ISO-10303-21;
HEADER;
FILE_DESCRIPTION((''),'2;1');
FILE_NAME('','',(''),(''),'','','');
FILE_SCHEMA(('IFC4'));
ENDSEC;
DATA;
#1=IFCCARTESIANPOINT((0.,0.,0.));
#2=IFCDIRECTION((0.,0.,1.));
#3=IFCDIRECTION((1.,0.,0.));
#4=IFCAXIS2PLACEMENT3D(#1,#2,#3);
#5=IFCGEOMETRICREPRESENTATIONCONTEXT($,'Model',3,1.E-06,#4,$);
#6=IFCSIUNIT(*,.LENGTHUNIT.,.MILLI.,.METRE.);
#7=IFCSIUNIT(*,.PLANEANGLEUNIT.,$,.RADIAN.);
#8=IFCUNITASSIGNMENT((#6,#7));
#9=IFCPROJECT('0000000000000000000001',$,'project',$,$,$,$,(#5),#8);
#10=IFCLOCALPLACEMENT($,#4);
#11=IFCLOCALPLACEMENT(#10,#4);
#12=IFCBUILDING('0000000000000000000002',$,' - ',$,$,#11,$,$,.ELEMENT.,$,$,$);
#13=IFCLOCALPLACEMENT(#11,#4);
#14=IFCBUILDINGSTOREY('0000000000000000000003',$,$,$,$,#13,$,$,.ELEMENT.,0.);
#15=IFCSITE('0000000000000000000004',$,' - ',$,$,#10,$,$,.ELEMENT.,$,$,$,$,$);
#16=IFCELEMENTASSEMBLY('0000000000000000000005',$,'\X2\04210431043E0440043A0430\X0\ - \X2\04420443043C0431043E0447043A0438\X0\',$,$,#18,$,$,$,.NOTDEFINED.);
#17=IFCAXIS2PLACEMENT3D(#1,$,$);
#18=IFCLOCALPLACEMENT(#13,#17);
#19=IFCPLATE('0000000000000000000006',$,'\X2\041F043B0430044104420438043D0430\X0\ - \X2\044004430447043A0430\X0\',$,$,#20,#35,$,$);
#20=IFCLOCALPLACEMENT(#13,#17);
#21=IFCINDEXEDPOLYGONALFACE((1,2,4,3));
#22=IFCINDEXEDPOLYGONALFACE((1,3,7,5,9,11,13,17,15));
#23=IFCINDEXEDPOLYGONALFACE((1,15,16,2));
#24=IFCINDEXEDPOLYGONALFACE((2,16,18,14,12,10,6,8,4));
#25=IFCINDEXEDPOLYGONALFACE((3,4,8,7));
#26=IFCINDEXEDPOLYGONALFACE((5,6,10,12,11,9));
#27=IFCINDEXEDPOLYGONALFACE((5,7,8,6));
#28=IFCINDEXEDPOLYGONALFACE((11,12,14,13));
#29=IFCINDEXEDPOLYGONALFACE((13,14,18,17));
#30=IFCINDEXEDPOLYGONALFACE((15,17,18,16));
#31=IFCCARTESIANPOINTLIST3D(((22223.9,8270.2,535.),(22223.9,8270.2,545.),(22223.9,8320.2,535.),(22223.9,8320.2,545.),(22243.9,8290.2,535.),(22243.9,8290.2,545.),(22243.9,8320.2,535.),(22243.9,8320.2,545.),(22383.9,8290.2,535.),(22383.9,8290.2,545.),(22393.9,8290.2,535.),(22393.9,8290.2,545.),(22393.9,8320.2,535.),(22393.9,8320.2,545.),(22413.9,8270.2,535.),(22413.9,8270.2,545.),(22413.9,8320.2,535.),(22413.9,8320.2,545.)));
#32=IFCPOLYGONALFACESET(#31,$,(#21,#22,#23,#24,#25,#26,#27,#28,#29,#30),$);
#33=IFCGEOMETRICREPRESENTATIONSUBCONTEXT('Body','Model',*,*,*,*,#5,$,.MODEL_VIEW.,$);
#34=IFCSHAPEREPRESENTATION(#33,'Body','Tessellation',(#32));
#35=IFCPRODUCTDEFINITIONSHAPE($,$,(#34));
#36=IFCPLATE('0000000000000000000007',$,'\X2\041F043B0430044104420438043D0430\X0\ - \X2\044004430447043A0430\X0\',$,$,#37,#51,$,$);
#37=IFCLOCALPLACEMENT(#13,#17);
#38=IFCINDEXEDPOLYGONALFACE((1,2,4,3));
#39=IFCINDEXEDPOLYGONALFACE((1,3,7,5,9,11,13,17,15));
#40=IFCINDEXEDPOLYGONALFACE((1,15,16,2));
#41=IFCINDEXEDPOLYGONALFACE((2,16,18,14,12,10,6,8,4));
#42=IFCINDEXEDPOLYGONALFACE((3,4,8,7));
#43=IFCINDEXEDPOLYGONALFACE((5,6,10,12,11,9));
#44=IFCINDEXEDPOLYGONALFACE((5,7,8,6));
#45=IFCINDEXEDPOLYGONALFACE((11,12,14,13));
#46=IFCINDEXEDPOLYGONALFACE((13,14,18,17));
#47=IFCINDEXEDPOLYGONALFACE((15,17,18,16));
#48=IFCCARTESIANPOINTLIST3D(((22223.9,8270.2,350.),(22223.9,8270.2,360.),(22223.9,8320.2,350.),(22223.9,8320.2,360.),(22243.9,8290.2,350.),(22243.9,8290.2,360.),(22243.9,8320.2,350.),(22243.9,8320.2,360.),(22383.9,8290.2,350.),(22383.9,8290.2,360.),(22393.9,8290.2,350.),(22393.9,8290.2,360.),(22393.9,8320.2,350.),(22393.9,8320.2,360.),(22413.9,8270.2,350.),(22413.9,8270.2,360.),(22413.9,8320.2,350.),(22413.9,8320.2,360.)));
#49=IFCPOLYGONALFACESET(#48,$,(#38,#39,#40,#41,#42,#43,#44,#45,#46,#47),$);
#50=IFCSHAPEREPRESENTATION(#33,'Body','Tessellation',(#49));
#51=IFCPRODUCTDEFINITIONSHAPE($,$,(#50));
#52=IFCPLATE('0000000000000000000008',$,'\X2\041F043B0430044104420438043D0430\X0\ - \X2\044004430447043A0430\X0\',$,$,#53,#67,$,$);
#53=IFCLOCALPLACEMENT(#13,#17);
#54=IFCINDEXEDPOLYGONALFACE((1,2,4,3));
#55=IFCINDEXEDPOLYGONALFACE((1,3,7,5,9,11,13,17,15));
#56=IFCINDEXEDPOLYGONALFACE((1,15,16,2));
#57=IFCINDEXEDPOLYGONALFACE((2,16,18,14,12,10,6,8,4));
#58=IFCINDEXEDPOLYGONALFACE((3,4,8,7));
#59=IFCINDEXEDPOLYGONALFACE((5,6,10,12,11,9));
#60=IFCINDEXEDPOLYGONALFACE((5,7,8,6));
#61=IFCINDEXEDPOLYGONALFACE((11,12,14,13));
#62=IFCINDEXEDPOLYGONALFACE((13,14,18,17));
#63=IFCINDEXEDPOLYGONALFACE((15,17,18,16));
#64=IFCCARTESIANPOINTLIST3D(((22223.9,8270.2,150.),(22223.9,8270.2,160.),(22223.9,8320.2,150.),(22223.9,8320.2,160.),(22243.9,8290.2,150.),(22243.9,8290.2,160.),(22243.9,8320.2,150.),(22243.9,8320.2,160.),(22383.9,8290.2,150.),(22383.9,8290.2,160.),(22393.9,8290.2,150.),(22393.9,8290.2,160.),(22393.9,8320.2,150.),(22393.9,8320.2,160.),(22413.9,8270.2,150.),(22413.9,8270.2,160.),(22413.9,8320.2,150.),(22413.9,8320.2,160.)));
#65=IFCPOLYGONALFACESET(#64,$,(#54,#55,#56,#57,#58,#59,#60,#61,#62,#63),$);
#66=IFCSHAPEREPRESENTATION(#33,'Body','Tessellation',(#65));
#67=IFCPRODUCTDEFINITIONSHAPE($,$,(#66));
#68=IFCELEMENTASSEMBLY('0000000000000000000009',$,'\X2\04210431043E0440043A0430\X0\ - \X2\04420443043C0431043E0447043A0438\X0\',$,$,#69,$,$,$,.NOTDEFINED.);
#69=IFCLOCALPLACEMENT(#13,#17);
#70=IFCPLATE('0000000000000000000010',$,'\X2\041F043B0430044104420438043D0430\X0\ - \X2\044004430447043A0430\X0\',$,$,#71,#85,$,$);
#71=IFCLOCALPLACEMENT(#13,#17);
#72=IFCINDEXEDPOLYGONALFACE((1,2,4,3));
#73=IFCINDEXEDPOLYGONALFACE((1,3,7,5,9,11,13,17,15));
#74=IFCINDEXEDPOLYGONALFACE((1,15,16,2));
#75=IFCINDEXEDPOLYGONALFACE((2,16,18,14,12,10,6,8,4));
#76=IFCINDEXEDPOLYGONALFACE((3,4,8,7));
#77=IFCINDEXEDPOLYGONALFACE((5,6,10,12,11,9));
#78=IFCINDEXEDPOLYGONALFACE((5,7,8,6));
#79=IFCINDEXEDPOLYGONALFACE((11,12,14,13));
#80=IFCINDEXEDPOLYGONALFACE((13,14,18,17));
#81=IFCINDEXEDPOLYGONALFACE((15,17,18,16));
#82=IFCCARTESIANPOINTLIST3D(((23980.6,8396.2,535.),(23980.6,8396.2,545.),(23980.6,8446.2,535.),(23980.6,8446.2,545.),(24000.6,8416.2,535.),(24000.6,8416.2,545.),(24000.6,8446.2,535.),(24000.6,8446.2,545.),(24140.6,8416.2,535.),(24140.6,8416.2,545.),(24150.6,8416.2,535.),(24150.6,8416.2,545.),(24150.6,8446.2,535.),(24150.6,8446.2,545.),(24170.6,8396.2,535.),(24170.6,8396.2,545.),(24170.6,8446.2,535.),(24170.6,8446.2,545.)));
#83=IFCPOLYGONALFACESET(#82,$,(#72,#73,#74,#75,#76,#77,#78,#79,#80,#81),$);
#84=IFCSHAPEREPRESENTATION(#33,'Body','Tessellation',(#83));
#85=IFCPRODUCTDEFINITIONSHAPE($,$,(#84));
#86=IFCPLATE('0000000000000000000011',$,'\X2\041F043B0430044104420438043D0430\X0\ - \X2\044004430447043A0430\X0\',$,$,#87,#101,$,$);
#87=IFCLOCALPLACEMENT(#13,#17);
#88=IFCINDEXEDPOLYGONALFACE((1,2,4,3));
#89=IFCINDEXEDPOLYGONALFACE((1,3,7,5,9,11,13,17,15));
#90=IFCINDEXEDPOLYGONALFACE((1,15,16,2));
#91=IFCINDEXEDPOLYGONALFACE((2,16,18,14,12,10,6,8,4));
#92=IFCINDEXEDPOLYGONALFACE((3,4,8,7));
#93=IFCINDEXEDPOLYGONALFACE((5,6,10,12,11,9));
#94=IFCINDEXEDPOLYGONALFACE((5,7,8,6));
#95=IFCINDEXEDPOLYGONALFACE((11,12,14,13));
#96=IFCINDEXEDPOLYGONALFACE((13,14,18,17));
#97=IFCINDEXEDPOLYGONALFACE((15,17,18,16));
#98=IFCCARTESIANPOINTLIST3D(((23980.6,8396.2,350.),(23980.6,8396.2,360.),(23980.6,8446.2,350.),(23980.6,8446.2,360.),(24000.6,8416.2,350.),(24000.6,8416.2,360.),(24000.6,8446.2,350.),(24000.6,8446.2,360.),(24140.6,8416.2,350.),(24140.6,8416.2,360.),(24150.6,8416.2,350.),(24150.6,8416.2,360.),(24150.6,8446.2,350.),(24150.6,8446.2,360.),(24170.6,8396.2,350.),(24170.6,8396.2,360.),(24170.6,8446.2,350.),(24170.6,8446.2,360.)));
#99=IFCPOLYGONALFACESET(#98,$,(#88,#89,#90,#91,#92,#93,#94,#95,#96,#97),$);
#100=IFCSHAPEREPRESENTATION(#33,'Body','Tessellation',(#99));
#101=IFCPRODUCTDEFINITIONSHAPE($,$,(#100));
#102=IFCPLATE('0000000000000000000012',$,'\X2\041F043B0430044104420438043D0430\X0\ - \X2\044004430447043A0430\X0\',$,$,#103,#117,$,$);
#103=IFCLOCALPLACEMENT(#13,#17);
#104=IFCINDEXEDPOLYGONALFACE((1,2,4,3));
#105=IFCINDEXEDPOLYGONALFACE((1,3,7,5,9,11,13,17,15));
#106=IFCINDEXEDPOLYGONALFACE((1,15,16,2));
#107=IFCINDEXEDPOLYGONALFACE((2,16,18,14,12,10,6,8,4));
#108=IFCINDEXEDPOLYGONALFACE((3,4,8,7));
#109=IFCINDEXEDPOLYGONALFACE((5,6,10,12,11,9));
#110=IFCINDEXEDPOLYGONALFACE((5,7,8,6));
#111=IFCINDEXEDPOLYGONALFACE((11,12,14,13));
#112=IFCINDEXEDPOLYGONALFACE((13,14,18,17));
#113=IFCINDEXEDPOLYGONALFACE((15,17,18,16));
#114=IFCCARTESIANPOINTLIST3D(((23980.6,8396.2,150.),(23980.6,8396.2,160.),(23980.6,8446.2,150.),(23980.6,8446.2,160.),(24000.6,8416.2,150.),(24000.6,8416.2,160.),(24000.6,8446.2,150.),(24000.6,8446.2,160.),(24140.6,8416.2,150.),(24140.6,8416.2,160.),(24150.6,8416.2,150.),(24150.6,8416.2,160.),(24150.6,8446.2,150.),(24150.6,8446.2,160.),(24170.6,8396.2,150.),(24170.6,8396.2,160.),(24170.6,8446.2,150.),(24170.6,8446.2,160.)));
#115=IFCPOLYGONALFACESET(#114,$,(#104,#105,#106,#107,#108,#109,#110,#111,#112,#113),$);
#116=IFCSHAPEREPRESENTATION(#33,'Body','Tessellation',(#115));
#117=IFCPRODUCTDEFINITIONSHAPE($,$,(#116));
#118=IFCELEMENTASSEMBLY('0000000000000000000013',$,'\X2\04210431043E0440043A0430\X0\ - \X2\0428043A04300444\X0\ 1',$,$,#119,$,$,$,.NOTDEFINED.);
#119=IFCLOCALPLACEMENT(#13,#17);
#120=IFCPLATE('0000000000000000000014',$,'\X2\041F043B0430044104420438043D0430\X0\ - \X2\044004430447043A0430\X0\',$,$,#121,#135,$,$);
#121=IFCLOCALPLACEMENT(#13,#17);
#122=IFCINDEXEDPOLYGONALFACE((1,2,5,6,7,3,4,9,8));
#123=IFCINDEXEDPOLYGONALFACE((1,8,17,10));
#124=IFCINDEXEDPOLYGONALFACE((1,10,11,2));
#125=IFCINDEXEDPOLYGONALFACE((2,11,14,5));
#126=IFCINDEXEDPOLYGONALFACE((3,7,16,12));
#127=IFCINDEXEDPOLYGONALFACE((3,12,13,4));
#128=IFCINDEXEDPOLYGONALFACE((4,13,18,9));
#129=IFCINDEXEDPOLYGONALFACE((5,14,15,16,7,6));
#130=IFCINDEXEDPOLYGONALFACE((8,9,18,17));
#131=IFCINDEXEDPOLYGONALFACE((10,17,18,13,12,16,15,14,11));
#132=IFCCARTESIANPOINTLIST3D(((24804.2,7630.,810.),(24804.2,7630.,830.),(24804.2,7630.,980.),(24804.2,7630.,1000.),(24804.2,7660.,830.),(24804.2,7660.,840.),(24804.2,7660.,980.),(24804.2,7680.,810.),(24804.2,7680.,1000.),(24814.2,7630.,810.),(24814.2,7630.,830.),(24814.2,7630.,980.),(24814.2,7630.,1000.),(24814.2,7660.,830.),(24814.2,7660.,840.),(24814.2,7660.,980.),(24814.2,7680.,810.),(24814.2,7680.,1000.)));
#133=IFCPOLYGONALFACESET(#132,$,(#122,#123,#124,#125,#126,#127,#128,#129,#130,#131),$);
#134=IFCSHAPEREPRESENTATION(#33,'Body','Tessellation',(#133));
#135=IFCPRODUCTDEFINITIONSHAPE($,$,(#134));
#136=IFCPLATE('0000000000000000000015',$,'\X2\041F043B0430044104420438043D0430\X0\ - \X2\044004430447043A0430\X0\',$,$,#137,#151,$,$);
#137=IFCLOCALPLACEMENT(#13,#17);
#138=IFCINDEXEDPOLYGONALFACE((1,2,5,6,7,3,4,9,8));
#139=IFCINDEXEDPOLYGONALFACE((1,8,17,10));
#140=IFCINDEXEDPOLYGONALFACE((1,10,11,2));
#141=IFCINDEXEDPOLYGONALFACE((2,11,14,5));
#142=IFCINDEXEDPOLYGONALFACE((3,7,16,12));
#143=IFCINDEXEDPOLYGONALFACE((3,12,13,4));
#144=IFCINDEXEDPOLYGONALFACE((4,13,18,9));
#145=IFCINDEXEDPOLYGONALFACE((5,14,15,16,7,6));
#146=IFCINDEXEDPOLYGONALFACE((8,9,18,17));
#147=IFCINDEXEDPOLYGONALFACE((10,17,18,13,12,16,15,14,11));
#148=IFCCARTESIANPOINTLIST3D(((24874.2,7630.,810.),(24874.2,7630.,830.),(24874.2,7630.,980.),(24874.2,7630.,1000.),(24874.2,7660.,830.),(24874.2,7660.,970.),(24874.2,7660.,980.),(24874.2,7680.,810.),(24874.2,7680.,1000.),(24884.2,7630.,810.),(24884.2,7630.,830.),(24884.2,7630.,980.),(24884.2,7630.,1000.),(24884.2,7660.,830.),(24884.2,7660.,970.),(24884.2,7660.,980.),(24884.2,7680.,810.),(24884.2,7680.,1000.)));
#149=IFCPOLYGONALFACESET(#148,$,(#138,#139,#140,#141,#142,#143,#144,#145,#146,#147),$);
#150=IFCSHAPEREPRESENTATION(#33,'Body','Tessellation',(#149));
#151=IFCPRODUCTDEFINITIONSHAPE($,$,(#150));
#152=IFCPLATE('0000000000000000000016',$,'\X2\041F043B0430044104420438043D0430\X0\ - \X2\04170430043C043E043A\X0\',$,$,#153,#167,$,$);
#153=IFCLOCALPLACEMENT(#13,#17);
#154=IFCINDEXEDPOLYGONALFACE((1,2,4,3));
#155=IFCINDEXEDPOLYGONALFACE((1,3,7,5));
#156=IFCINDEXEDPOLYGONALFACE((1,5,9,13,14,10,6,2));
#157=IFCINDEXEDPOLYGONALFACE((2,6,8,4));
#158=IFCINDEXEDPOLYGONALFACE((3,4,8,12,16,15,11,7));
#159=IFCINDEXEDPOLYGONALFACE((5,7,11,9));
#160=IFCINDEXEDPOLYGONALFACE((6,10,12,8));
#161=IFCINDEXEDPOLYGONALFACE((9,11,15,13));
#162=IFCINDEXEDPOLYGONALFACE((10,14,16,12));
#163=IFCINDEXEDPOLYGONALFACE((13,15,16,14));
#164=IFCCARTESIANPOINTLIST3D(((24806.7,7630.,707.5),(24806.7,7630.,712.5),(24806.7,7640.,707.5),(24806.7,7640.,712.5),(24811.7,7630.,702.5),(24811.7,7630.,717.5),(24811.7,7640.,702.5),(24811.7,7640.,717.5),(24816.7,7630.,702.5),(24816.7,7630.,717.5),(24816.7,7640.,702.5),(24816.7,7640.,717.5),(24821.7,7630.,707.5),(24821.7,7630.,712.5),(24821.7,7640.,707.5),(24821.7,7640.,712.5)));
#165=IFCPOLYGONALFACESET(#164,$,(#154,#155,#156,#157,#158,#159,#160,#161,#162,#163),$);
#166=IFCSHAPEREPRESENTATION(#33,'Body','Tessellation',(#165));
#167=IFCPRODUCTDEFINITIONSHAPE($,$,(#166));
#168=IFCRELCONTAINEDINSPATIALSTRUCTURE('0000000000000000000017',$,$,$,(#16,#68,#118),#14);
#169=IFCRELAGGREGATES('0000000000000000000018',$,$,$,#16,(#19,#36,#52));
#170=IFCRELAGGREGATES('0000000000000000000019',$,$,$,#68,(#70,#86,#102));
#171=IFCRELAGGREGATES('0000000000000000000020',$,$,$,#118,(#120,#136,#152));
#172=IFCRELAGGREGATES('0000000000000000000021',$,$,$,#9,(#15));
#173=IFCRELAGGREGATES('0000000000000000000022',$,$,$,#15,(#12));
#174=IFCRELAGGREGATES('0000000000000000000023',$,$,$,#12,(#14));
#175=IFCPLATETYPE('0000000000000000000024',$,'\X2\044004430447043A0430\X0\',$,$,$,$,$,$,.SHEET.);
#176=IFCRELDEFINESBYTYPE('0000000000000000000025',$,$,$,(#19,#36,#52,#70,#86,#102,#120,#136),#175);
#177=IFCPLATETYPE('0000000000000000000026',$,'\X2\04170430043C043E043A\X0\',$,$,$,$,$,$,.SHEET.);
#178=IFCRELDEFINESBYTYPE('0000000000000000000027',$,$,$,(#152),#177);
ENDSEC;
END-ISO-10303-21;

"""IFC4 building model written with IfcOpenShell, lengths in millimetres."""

from ifc_helpers import new_model, si_unit, frame, origin_with_axes, place, context, subcontext, project, spatial, line, indexed_curve, outline, extrude, source, transform, mapped, type_object, element, aggregate, save


model = new_model("IFC4")

# Units and contexts
model_context = context("Model", 3, precision=1e-06, world=origin_with_axes())
body_context = subcontext(model_context, "Body", "Model", "MODEL_VIEW")
ifc_project = project(units=[si_unit("LENGTHUNIT", "METRE", prefix="MILLI"), si_unit("PLANEANGLEUNIT", "RADIAN")], contexts=[model_context])

# Site, building, storey
site_placement = place(None, origin_with_axes())
site = spatial("IfcSite", under=ifc_project, at=site_placement, Name=" - ", CompositionType="ELEMENT")
building_placement = place(site_placement, origin_with_axes())
building = spatial("IfcBuilding", under=site, at=building_placement, Name=" - ", CompositionType="ELEMENT")
storey_placement = place(building_placement, origin_with_axes())
storey = spatial("IfcBuildingStorey", under=building, at=storey_placement, CompositionType="ELEMENT", Elevation=0.0)

# Shared definitions
plate_type_1 = type_object("IfcPlateType", Name="ручка", PredefinedType="SHEET")
shared_shape_1 = source(origin_with_axes(), body_context, "Body", "SweptSolid", [
    extrude(outline(indexed_curve([(-95.0, -25.0), (-75.0, -25.0), (-75.0, 5.0), (-65.0, 5.0), (75.0, 5.0), (75.0, -25.0), (95.0, -25.0), (95.0, 25.0), (-95.0, 25.0)], segments=[line(1, 2), line(2, 3), line(3, 4), line(4, 5), line(5, 6), line(6, 7), line(7, 8), line(8, 9), line(9, 1)])), origin_with_axes(), (0.0, 0.0, 1.0), 10.0),
])

# Element assemblies, plates
assembly_1_placement = place(storey_placement, frame((22118.9, 8320.2, 0.0), z_axis=(0.0, 0.0, 1.0), x_axis=(1.0, 0.0, 0.0)))
assembly_1 = element("IfcElementAssembly", 1, at=assembly_1_placement, inside=storey, Name="Сборка - тумбочки", PredefinedType="NOTDEFINED")
plate_1_placement = place(assembly_1_placement, frame((200.0, -25.0, 535.0), z_axis=(0.0, 0.0, 1.0), x_axis=(-1.0, 0.0, 0.0)))
plate_1 = element("IfcPlate", 2, at=plate_1_placement, type_object=plate_type_1, Name="Пластина - ручка", context=body_context, shape_type="MappedRepresentation", body=[
    mapped(shared_shape_1, transform((0.0, 0.0, 0.0), x_axis=(1.0, 0.0, 0.0), y_axis=(0.0, 1.0, 0.0), z_axis=(0.0, 0.0, 1.0), scale=1.0)),
])
plate_2_placement = place(assembly_1_placement, frame((200.0, -25.0, 350.0), z_axis=(0.0, 0.0, 1.0), x_axis=(-1.0, 0.0, 0.0)))
plate_2 = element("IfcPlate", 3, at=plate_2_placement, type_object=plate_type_1, Name="Пластина - ручка", context=body_context, shape_type="MappedRepresentation", body=[
    mapped(shared_shape_1, transform((0.0, 0.0, 0.0), x_axis=(1.0, 0.0, 0.0), y_axis=(0.0, 1.0, 0.0), z_axis=(0.0, 0.0, 1.0), scale=1.0)),
])
plate_3_placement = place(assembly_1_placement, frame((200.0, -25.0, 150.0), z_axis=(0.0, 0.0, 1.0), x_axis=(-1.0, 0.0, 0.0)))
plate_3 = element("IfcPlate", 4, at=plate_3_placement, type_object=plate_type_1, Name="Пластина - ручка", context=body_context, shape_type="MappedRepresentation", body=[
    mapped(shared_shape_1, transform((0.0, 0.0, 0.0), x_axis=(1.0, 0.0, 0.0), y_axis=(0.0, 1.0, 0.0), z_axis=(0.0, 0.0, 1.0), scale=1.0)),
])
aggregate(assembly_1, [plate_1, plate_2, plate_3])
assembly_2_placement = place(storey_placement, frame((23875.6, 8446.2, 0.0), z_axis=(0.0, 0.0, 1.0), x_axis=(1.0, 0.0, 0.0)))
assembly_2 = element("IfcElementAssembly", 5, at=assembly_2_placement, inside=storey, Name="Сборка - тумбочки", PredefinedType="NOTDEFINED")
plate_4_placement = place(assembly_2_placement, frame((200.0, -25.0, 535.0), z_axis=(0.0, 0.0, 1.0), x_axis=(-1.0, 0.0, 0.0)))
plate_4 = element("IfcPlate", 6, at=plate_4_placement, type_object=plate_type_1, Name="Пластина - ручка", context=body_context, shape_type="MappedRepresentation", body=[
    mapped(shared_shape_1, transform((0.0, 0.0, 0.0), x_axis=(1.0, 0.0, 0.0), y_axis=(0.0, 1.0, 0.0), z_axis=(0.0, 0.0, 1.0), scale=1.0)),
])
plate_5_placement = place(assembly_2_placement, frame((200.0, -25.0, 350.0), z_axis=(0.0, 0.0, 1.0), x_axis=(-1.0, 0.0, 0.0)))
plate_5 = element("IfcPlate", 7, at=plate_5_placement, type_object=plate_type_1, Name="Пластина - ручка", context=body_context, shape_type="MappedRepresentation", body=[
    mapped(shared_shape_1, transform((0.0, 0.0, 0.0), x_axis=(1.0, 0.0, 0.0), y_axis=(0.0, 1.0, 0.0), z_axis=(0.0, 0.0, 1.0), scale=1.0)),
])
plate_6_placement = place(assembly_2_placement, frame((200.0, -25.0, 150.0), z_axis=(0.0, 0.0, 1.0), x_axis=(-1.0, 0.0, 0.0)))
plate_6 = element("IfcPlate", 8, at=plate_6_placement, type_object=plate_type_1, Name="Пластина - ручка", context=body_context, shape_type="MappedRepresentation", body=[
    mapped(shared_shape_1, transform((0.0, 0.0, 0.0), x_axis=(1.0, 0.0, 0.0), y_axis=(0.0, 1.0, 0.0), z_axis=(0.0, 0.0, 1.0), scale=1.0)),
])
aggregate(assembly_2, [plate_4, plate_5, plate_6])
assembly_3_placement = place(storey_placement, frame((25244.2, 7630.0, 0.0), z_axis=(0.0, 0.0, 1.0), x_axis=(-1.0, 0.0, 0.0)))
assembly_3 = element("IfcElementAssembly", 9, at=assembly_3_placement, inside=storey, Name="Сборка - Шкаф 1", PredefinedType="NOTDEFINED")
shared_shape_2 = source(origin_with_axes(), body_context, "Body", "SweptSolid", [
    extrude(outline(indexed_curve([(-95.0, -25.0), (-75.0, -25.0), (-75.0, 5.0), (-65.0, 5.0), (75.0, 5.0), (75.0, -25.0), (95.0, -25.0), (95.0, 25.0), (-95.0, 25.0)], segments=[line(1, 2), line(2, 3), line(3, 4), line(4, 5), line(5, 6), line(6, 7), line(7, 8), line(8, 9), line(9, 1)])), origin_with_axes(), (0.0, 0.0, 1.0), 10.0),
])
plate_7_placement = place(assembly_3_placement, frame((430.0, -25.0, 905.0), z_axis=(1.0, 0.0, 0.0), x_axis=(0.0, 0.0, 1.0)))
plate_7 = element("IfcPlate", 10, at=plate_7_placement, type_object=plate_type_1, Name="Пластина - ручка", context=body_context, shape_type="MappedRepresentation", body=[
    mapped(shared_shape_2, transform((0.0, 0.0, 0.0), x_axis=(1.0, 0.0, 0.0), y_axis=(0.0, 1.0, 0.0), z_axis=(0.0, 0.0, 1.0), scale=1.0)),
])
shared_shape_3 = source(origin_with_axes(), body_context, "Body", "SweptSolid", [
    extrude(outline(indexed_curve([(-95.0, -25.0), (-75.0, -25.0), (-75.0, 5.0), (-65.0, 5.0), (75.0, 5.0), (75.0, -25.0), (95.0, -25.0), (95.0, 25.0), (-95.0, 25.0)], segments=[line(1, 2), line(2, 3), line(3, 4), line(4, 5), line(5, 6), line(6, 7), line(7, 8), line(8, 9), line(9, 1)])), origin_with_axes(), (0.0, 0.0, 1.0), 10.0),
])
plate_8_placement = place(assembly_3_placement, frame((370.0, -25.0, 905.0), z_axis=(-1.0, 0.0, 0.0), x_axis=(0.0, 0.0, -1.0)))
plate_8 = element("IfcPlate", 11, at=plate_8_placement, type_object=plate_type_1, Name="Пластина - ручка", context=body_context, shape_type="MappedRepresentation", body=[
    mapped(shared_shape_3, transform((0.0, 0.0, 0.0), x_axis=(1.0, 0.0, 0.0), y_axis=(0.0, 1.0, 0.0), z_axis=(0.0, 0.0, 1.0), scale=1.0)),
])
plate_type_2 = type_object("IfcPlateType", Name="Замок", PredefinedType="SHEET")
shared_shape_4 = source(origin_with_axes(), body_context, "Body", "SweptSolid", [
    extrude(outline(indexed_curve([(-2.5, 7.5), (-7.5, 2.5), (-7.5, -2.5), (-2.5, -7.5), (2.5, -7.5), (7.5, -2.5), (7.5, 2.5), (2.5, 7.5)], segments=[line(1, 2), line(2, 3), line(3, 4), line(4, 5), line(5, 6), line(6, 7), line(7, 8), line(8, 1)])), origin_with_axes(), (0.0, 0.0, 1.0), 10.0),
])
plate_9_placement = place(assembly_3_placement, frame((430.0, 0.0, 710.0), z_axis=(0.0, -1.0, 0.0), x_axis=(0.0, 0.0, 1.0)))
plate_9 = element("IfcPlate", 12, at=plate_9_placement, type_object=plate_type_2, Name="Пластина - Замок", context=body_context, shape_type="MappedRepresentation", body=[
    mapped(shared_shape_4, transform((0.0, 0.0, 0.0), x_axis=(1.0, 0.0, 0.0), y_axis=(0.0, 1.0, 0.0), z_axis=(0.0, 0.0, 1.0), scale=1.0)),
])
aggregate(assembly_3, [plate_7, plate_8, plate_9])

save(model, "model.ifc")
